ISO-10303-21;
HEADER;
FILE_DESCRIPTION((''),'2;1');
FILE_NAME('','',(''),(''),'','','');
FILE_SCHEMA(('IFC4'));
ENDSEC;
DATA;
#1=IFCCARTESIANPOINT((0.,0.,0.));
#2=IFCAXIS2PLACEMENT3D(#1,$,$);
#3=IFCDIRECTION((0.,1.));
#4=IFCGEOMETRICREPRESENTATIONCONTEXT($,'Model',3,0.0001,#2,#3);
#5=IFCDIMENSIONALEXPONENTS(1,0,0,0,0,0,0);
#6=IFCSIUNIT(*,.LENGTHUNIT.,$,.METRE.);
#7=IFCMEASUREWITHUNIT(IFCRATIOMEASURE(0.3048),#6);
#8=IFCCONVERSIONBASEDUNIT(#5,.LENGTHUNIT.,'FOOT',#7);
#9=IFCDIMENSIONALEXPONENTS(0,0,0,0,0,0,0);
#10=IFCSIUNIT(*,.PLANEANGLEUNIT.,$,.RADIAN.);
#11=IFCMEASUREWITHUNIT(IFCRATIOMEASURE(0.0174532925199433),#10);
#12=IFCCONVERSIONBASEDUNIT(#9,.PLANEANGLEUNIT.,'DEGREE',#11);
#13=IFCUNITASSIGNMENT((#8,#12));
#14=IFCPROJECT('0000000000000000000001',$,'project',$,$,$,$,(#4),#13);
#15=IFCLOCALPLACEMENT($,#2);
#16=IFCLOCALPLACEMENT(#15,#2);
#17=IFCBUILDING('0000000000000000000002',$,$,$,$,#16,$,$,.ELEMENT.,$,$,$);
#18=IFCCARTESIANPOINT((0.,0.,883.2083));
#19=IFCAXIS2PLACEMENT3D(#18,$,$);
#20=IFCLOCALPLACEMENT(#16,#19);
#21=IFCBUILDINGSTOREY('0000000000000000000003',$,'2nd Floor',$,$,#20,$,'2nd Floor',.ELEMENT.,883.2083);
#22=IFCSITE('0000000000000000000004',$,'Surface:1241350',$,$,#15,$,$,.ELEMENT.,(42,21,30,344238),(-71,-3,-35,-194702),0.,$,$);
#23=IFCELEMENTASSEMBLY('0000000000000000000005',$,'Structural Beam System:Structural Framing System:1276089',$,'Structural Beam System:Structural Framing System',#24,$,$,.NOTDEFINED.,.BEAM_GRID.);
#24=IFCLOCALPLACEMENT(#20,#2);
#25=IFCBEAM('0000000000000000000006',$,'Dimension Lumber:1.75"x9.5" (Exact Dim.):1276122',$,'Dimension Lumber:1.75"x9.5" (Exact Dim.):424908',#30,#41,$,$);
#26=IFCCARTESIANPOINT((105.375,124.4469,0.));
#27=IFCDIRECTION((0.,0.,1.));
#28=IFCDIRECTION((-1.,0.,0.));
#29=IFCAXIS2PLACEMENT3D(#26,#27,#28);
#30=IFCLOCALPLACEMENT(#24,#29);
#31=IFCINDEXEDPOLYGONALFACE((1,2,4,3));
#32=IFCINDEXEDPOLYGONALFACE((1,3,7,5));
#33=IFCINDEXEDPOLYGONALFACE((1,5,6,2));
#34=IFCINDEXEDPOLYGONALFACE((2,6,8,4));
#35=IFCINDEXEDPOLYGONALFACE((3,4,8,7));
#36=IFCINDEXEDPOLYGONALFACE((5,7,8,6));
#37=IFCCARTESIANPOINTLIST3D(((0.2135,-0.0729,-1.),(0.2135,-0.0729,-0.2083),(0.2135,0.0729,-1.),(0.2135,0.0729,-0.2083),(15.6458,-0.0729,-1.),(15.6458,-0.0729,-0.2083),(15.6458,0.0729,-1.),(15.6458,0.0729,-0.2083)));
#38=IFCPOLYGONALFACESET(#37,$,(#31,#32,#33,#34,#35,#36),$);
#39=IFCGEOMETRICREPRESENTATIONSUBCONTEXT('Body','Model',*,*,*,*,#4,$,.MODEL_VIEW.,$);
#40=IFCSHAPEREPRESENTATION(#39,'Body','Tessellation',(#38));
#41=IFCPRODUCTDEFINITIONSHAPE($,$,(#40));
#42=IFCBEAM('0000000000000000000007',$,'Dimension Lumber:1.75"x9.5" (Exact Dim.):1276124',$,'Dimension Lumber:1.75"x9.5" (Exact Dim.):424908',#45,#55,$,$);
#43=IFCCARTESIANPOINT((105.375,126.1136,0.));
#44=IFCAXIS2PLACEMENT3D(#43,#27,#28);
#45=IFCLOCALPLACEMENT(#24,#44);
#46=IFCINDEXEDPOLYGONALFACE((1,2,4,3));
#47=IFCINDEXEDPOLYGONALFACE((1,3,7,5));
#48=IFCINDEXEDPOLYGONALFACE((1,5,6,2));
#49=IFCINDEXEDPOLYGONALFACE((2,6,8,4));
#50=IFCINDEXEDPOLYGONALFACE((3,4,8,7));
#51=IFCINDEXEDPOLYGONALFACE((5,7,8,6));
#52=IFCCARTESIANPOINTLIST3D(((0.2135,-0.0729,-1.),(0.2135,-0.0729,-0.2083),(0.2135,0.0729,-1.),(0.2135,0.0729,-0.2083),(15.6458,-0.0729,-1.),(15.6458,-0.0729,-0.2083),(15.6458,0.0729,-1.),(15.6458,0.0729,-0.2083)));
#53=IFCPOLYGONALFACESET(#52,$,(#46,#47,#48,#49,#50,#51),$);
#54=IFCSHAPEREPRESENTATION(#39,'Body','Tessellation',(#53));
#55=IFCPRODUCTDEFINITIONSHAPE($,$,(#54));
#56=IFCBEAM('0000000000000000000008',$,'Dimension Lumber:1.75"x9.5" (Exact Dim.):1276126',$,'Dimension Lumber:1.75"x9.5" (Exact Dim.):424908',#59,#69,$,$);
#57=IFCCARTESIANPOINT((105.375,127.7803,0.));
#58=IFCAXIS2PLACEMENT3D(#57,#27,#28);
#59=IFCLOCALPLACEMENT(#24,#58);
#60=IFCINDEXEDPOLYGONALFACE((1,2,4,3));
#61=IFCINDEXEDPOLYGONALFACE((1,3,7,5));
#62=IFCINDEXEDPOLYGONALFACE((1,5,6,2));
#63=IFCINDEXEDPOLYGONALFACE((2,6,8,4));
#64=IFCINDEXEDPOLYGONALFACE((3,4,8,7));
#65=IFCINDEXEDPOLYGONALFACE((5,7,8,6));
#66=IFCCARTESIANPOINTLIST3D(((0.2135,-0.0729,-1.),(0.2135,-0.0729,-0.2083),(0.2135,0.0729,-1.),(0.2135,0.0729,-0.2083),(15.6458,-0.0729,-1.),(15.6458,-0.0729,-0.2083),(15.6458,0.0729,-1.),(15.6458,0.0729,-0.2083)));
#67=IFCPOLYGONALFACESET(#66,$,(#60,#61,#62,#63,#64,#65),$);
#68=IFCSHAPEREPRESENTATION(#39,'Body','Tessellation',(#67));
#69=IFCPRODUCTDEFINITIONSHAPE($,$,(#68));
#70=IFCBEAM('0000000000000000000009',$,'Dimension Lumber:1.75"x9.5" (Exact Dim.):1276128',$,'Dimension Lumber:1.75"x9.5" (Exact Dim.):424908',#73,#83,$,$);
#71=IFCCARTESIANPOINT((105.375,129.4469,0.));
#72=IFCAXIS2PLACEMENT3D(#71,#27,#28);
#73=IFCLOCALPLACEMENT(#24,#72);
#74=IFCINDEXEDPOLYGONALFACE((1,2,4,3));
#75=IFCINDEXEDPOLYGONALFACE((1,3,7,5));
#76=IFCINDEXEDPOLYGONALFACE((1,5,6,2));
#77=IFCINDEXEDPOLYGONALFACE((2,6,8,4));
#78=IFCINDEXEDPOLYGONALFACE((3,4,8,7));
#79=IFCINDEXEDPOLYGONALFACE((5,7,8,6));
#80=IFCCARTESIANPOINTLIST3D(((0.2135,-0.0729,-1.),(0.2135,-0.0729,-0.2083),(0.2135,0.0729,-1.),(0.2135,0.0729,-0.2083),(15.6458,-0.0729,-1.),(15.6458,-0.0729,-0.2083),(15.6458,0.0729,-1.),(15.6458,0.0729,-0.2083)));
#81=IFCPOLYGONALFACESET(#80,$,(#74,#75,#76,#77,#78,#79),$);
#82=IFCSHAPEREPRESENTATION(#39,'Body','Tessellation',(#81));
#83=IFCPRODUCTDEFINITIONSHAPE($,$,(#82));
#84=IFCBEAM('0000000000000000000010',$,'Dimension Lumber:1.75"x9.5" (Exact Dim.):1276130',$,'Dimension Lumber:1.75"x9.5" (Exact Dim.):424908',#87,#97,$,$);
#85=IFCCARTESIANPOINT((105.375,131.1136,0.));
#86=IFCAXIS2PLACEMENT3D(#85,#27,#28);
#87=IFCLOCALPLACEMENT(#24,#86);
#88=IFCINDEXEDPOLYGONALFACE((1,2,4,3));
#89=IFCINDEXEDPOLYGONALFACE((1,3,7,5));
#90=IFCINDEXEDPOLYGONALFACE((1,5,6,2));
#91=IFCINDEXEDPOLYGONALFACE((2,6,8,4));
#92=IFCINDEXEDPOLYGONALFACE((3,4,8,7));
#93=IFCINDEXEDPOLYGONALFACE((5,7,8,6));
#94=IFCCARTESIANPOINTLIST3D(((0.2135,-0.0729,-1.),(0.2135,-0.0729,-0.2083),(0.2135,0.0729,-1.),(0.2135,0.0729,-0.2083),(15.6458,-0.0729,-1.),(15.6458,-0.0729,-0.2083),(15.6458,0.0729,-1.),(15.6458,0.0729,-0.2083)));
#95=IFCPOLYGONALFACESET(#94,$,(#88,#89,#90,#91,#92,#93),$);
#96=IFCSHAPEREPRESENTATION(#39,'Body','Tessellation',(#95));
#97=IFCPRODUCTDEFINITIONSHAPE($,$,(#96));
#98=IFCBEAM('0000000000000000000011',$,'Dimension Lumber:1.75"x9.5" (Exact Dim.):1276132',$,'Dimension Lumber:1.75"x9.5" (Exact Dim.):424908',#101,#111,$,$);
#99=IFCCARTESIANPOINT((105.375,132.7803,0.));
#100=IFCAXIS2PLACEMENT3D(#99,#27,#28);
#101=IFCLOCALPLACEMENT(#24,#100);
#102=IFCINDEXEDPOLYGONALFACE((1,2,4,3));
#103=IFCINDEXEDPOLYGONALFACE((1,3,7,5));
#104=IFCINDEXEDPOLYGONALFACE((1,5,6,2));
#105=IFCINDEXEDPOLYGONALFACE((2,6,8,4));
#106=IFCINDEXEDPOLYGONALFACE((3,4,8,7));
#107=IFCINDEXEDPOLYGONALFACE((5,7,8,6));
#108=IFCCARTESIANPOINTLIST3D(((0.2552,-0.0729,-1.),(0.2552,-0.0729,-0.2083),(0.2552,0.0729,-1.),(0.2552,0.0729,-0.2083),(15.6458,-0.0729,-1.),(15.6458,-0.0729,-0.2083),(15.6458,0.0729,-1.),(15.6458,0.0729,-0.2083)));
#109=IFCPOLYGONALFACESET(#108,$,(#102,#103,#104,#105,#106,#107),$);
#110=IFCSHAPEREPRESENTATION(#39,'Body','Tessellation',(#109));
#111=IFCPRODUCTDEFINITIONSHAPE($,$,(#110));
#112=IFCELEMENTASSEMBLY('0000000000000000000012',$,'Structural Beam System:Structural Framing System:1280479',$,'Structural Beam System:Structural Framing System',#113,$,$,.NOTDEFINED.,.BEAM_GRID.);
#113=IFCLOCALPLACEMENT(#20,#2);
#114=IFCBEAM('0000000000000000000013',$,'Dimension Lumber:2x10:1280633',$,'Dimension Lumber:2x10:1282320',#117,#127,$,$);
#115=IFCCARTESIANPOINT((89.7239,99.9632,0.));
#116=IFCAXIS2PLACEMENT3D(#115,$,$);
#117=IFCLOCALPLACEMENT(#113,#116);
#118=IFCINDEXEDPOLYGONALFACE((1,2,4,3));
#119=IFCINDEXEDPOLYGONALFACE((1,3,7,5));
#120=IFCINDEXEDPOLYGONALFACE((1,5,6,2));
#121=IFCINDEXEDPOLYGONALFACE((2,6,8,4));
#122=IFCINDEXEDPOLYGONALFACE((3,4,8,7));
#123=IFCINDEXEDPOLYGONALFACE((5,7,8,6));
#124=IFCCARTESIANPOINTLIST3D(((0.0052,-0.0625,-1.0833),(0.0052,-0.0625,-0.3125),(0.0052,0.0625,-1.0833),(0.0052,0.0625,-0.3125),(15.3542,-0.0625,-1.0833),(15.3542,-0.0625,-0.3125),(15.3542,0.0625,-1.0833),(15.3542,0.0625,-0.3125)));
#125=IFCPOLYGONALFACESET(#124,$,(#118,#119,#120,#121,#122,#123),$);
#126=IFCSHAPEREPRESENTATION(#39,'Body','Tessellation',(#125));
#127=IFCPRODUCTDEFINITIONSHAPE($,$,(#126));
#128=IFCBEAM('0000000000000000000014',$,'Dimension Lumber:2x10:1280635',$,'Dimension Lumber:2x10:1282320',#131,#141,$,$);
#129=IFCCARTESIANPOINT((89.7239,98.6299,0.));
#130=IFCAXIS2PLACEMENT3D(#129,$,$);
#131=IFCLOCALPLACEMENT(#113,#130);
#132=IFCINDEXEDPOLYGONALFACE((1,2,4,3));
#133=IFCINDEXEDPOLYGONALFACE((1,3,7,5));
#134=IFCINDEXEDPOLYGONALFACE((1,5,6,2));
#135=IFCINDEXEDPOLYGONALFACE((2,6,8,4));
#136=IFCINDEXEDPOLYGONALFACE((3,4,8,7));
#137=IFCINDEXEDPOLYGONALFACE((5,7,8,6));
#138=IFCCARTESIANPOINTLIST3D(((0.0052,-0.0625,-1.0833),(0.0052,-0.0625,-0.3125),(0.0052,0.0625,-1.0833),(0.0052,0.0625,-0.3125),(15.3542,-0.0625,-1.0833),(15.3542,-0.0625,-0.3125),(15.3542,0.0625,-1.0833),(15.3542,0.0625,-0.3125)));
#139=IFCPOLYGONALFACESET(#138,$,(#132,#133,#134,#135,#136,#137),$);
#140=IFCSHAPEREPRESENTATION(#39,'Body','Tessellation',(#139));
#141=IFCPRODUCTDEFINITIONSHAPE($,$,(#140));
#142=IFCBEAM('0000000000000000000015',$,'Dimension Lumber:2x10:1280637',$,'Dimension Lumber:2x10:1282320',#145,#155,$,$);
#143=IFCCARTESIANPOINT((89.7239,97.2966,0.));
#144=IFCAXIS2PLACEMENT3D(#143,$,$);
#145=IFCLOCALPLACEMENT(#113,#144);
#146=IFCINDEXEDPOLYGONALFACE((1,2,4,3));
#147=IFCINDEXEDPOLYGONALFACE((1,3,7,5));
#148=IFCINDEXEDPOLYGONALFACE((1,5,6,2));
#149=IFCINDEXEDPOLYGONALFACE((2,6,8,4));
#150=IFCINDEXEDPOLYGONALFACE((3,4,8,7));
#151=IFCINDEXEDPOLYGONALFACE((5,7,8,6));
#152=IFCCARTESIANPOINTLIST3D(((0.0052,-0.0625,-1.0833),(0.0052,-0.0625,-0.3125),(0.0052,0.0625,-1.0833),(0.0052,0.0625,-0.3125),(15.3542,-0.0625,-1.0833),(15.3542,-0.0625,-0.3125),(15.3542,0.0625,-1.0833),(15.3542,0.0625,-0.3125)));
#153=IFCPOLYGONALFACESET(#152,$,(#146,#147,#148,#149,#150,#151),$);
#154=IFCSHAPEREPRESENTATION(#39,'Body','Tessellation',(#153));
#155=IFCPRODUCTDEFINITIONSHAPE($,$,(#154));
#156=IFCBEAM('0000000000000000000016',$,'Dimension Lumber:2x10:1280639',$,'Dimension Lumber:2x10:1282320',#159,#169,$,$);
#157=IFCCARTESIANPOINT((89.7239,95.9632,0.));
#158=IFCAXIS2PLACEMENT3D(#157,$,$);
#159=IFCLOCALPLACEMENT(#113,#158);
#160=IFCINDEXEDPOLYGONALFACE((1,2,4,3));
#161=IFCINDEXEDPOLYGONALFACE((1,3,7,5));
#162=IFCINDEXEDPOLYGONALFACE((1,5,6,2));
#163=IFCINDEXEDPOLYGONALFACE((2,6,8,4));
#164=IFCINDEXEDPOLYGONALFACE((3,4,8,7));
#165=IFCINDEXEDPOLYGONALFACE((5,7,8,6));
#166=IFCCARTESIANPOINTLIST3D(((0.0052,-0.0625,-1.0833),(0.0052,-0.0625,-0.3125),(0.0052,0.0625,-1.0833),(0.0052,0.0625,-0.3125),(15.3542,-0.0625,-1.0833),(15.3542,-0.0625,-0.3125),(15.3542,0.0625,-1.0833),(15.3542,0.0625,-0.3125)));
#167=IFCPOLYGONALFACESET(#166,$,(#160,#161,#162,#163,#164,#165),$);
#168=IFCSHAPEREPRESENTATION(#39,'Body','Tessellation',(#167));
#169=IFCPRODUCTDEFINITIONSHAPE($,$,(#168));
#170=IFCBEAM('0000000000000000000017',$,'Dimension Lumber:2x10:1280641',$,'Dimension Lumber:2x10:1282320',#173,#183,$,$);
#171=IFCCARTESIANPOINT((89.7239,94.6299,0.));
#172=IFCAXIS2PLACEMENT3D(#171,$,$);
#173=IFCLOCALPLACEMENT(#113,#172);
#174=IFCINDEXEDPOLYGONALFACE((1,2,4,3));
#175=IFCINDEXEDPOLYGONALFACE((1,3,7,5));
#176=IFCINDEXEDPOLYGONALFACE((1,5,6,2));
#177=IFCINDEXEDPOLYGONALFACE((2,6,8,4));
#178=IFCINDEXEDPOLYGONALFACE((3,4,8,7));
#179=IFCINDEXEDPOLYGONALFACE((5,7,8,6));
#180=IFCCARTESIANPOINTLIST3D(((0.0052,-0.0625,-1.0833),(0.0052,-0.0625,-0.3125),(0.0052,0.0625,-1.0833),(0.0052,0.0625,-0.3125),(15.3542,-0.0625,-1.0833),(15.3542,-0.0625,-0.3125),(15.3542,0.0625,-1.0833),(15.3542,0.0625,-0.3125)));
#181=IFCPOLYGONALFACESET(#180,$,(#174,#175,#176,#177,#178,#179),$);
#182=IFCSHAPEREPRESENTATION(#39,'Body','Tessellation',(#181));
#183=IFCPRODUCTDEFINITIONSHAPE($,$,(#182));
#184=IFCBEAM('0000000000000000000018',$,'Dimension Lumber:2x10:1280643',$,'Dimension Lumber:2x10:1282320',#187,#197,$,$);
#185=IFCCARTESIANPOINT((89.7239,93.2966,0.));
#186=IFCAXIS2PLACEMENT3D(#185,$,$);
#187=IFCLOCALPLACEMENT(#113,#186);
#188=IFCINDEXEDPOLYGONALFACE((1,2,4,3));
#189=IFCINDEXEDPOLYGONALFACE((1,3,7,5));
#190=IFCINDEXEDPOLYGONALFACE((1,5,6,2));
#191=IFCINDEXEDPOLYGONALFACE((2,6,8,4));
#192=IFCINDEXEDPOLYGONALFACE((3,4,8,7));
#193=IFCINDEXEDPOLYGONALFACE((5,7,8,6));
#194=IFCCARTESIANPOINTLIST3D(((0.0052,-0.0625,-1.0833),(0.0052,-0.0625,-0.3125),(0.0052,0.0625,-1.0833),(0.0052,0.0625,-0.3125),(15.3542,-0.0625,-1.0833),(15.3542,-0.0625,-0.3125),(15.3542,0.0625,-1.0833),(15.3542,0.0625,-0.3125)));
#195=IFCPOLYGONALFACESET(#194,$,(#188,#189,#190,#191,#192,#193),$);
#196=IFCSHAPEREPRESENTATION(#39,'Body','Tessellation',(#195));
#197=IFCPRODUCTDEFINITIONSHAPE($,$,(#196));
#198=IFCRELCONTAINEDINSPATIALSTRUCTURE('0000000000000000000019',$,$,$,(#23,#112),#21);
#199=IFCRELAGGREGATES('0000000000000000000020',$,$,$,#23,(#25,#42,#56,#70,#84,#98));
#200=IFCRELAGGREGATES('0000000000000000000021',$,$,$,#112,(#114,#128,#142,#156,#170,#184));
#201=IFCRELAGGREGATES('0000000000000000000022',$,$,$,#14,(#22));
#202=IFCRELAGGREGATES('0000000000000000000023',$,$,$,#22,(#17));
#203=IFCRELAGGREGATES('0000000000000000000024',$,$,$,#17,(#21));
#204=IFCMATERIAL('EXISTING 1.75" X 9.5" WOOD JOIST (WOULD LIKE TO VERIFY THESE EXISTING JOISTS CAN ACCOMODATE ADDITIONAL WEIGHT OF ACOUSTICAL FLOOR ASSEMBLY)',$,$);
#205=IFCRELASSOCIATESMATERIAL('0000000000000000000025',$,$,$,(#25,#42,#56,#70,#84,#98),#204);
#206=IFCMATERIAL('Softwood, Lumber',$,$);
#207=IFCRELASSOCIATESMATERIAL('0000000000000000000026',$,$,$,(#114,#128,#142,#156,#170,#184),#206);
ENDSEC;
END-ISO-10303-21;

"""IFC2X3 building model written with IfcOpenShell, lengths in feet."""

from ifc_helpers import new_model, entity, si_unit, converted_unit, direction, frame, frame_2d, origin, origin_2d_with_axis, place, context, subcontext, project, spatial, rectangle, extrude, material, element, aggregate, save


model = new_model("IFC2X3")

# Units and contexts
model_context = context("Model", 3, precision=0.0001, world=origin(), true_north=direction((0.0, 1.0)))
body_context = subcontext(model_context, "Body", "Model", "MODEL_VIEW")
ifc_project = project(units=[converted_unit("LENGTHUNIT", "FOOT", entity("IfcRatioMeasure", 0.3048), si_unit("LENGTHUNIT", "METRE"), dimensions=[1, 0, 0, 0, 0, 0, 0]), converted_unit("PLANEANGLEUNIT", "DEGREE", entity("IfcRatioMeasure", 0.0174532925199433), si_unit("PLANEANGLEUNIT", "RADIAN"), dimensions=[0, 0, 0, 0, 0, 0, 0])], contexts=[model_context])

# Site, building, storey
site_placement = place(None, origin())
site = spatial("IfcSite", under=ifc_project, at=site_placement, Name="Surface:1241350", CompositionType="ELEMENT", RefLatitude=(42, 21, 30, 344238), RefLongitude=(-71, -3, -35, -194702), RefElevation=0.0)
building_placement = place(site_placement, origin())
building = spatial("IfcBuilding", under=site, at=building_placement, CompositionType="ELEMENT")
storey_placement = place(building_placement, frame((0.0, 0.0, 883.2083)))
storey = spatial("IfcBuildingStorey", under=building, at=storey_placement, Name="2nd Floor", LongName="2nd Floor", CompositionType="ELEMENT", Elevation=883.2083)

# Element assemblies, beams
assembly_1_placement = place(storey_placement, origin())
assembly_1 = element("IfcElementAssembly", 1, at=assembly_1_placement, inside=storey, Name="Structural Beam System:Structural Framing System:1276089", ObjectType="Structural Beam System:Structural Framing System", AssemblyPlace="NOTDEFINED", PredefinedType="BEAM_GRID")
ifc_material_1 = material(Name="EXISTING 1.75\" X 9.5\" WOOD JOIST (WOULD LIKE TO VERIFY THESE EXISTING JOISTS CAN ACCOMODATE ADDITIONAL WEIGHT OF ACOUSTICAL FLOOR ASSEMBLY)")
beam_1_placement = place(assembly_1_placement, frame((105.375, 124.4469, 0.0), z_axis=(0.0, 0.0, 1.0), x_axis=(-1.0, 0.0, 0.0)))
beam_1 = element("IfcBeam", 2, at=beam_1_placement, material=ifc_material_1, Name="Dimension Lumber:1.75\"x9.5\" (Exact Dim.):1276122", ObjectType="Dimension Lumber:1.75\"x9.5\" (Exact Dim.):424908", context=body_context, shape_type="SweptSolid", body=[
    extrude(rectangle(XDim=0.7917, YDim=0.1458, at=origin_2d_with_axis()), frame((0.2135, 0.0, -0.6042), z_axis=(1.0, 0.0, 0.0), x_axis=(0.0, 0.0, -1.0)), (0.0, 0.0, 1.0), 15.4323),
])
beam_2_placement = place(assembly_1_placement, frame((105.375, 126.1136, 0.0), z_axis=(0.0, 0.0, 1.0), x_axis=(-1.0, 0.0, 0.0)))
beam_2 = element("IfcBeam", 3, at=beam_2_placement, material=ifc_material_1, Name="Dimension Lumber:1.75\"x9.5\" (Exact Dim.):1276124", ObjectType="Dimension Lumber:1.75\"x9.5\" (Exact Dim.):424908", context=body_context, shape_type="SweptSolid", body=[
    extrude(rectangle(XDim=0.7917, YDim=0.1458, at=origin_2d_with_axis()), frame((0.2135, 0.0, -0.6042), z_axis=(1.0, 0.0, 0.0), x_axis=(0.0, 0.0, -1.0)), (0.0, 0.0, 1.0), 15.4323),
])
beam_3_placement = place(assembly_1_placement, frame((105.375, 127.7803, 0.0), z_axis=(0.0, 0.0, 1.0), x_axis=(-1.0, 0.0, 0.0)))
beam_3 = element("IfcBeam", 4, at=beam_3_placement, material=ifc_material_1, Name="Dimension Lumber:1.75\"x9.5\" (Exact Dim.):1276126", ObjectType="Dimension Lumber:1.75\"x9.5\" (Exact Dim.):424908", context=body_context, shape_type="SweptSolid", body=[
    extrude(rectangle(XDim=0.7917, YDim=0.1458, at=frame_2d((0.0, 0.0), x_axis=(1.0, 0.0))), frame((0.2135, 0.0, -0.6042), z_axis=(1.0, 0.0, 0.0), x_axis=(0.0, 0.0, -1.0)), (0.0, 0.0, 1.0), 15.4323),
])
beam_4_placement = place(assembly_1_placement, frame((105.375, 129.4469, 0.0), z_axis=(0.0, 0.0, 1.0), x_axis=(-1.0, 0.0, 0.0)))
beam_4 = element("IfcBeam", 5, at=beam_4_placement, material=ifc_material_1, Name="Dimension Lumber:1.75\"x9.5\" (Exact Dim.):1276128", ObjectType="Dimension Lumber:1.75\"x9.5\" (Exact Dim.):424908", context=body_context, shape_type="SweptSolid", body=[
    extrude(rectangle(XDim=0.7917, YDim=0.1458, at=frame_2d((0.0, 0.0), x_axis=(1.0, 0.0))), frame((0.2135, 0.0, -0.6042), z_axis=(1.0, 0.0, 0.0), x_axis=(0.0, 0.0, -1.0)), (0.0, 0.0, 1.0), 15.4323),
])
beam_5_placement = place(assembly_1_placement, frame((105.375, 131.1136, 0.0), z_axis=(0.0, 0.0, 1.0), x_axis=(-1.0, 0.0, 0.0)))
beam_5 = element("IfcBeam", 6, at=beam_5_placement, material=ifc_material_1, Name="Dimension Lumber:1.75\"x9.5\" (Exact Dim.):1276130", ObjectType="Dimension Lumber:1.75\"x9.5\" (Exact Dim.):424908", context=body_context, shape_type="SweptSolid", body=[
    extrude(rectangle(XDim=0.7917, YDim=0.1458, at=frame_2d((0.0, 0.0), x_axis=(1.0, 0.0))), frame((0.2135, 0.0, -0.6042), z_axis=(1.0, 0.0, 0.0), x_axis=(0.0, 0.0, -1.0)), (0.0, 0.0, 1.0), 15.4323),
])
beam_6_placement = place(assembly_1_placement, frame((105.375, 132.7803, 0.0), z_axis=(0.0, 0.0, 1.0), x_axis=(-1.0, 0.0, 0.0)))
beam_6 = element("IfcBeam", 7, at=beam_6_placement, material=ifc_material_1, Name="Dimension Lumber:1.75\"x9.5\" (Exact Dim.):1276132", ObjectType="Dimension Lumber:1.75\"x9.5\" (Exact Dim.):424908", context=body_context, shape_type="SweptSolid", body=[
    extrude(rectangle(XDim=0.7917, YDim=0.1458, at=frame_2d((0.0, 0.0), x_axis=(1.0, 0.0))), frame((0.2552, 0.0, -0.6042), z_axis=(1.0, 0.0, 0.0), x_axis=(0.0, 0.0, -1.0)), (0.0, 0.0, 1.0), 15.3906),
])
aggregate(assembly_1, [beam_1, beam_2, beam_3, beam_4, beam_5, beam_6])
assembly_2_placement = place(storey_placement, origin())
assembly_2 = element("IfcElementAssembly", 8, at=assembly_2_placement, inside=storey, Name="Structural Beam System:Structural Framing System:1280479", ObjectType="Structural Beam System:Structural Framing System", AssemblyPlace="NOTDEFINED", PredefinedType="BEAM_GRID")
ifc_material_2 = material(Name="Softwood, Lumber")
beam_7_placement = place(assembly_2_placement, frame((89.7239, 99.9632, 0.0)))
beam_7 = element("IfcBeam", 9, at=beam_7_placement, material=ifc_material_2, Name="Dimension Lumber:2x10:1280633", ObjectType="Dimension Lumber:2x10:1282320", context=body_context, shape_type="SweptSolid", body=[
    extrude(rectangle(XDim=0.7708, YDim=0.125, at=frame_2d((0.0, 0.0), x_axis=(1.0, 0.0))), frame((0.0052, 0.0, -0.6979), z_axis=(1.0, 0.0, 0.0), x_axis=(0.0, 0.0, -1.0)), (0.0, 0.0, 1.0), 15.349),
])
beam_8_placement = place(assembly_2_placement, frame((89.7239, 98.6299, 0.0)))
beam_8 = element("IfcBeam", 10, at=beam_8_placement, material=ifc_material_2, Name="Dimension Lumber:2x10:1280635", ObjectType="Dimension Lumber:2x10:1282320", context=body_context, shape_type="SweptSolid", body=[
    extrude(rectangle(XDim=0.7708, YDim=0.125, at=frame_2d((0.0, 0.0), x_axis=(1.0, 0.0))), frame((0.0052, 0.0, -0.6979), z_axis=(1.0, 0.0, 0.0), x_axis=(0.0, 0.0, -1.0)), (0.0, 0.0, 1.0), 15.349),
])
beam_9_placement = place(assembly_2_placement, frame((89.7239, 97.2966, 0.0)))
beam_9 = element("IfcBeam", 11, at=beam_9_placement, material=ifc_material_2, Name="Dimension Lumber:2x10:1280637", ObjectType="Dimension Lumber:2x10:1282320", context=body_context, shape_type="SweptSolid", body=[
    extrude(rectangle(XDim=0.7708, YDim=0.125, at=frame_2d((0.0, 0.0), x_axis=(1.0, 0.0))), frame((0.0052, 0.0, -0.6979), z_axis=(1.0, 0.0, 0.0), x_axis=(0.0, 0.0, -1.0)), (0.0, 0.0, 1.0), 15.349),
])
beam_10_placement = place(assembly_2_placement, frame((89.7239, 95.9632, 0.0)))
beam_10 = element("IfcBeam", 12, at=beam_10_placement, material=ifc_material_2, Name="Dimension Lumber:2x10:1280639", ObjectType="Dimension Lumber:2x10:1282320", context=body_context, shape_type="SweptSolid", body=[
    extrude(rectangle(XDim=0.7708, YDim=0.125, at=frame_2d((0.0, 0.0), x_axis=(1.0, 0.0))), frame((0.0052, 0.0, -0.6979), z_axis=(1.0, 0.0, 0.0), x_axis=(0.0, 0.0, -1.0)), (0.0, 0.0, 1.0), 15.349),
])
beam_11_placement = place(assembly_2_placement, frame((89.7239, 94.6299, 0.0)))
beam_11 = element("IfcBeam", 13, at=beam_11_placement, material=ifc_material_2, Name="Dimension Lumber:2x10:1280641", ObjectType="Dimension Lumber:2x10:1282320", context=body_context, shape_type="SweptSolid", body=[
    extrude(rectangle(XDim=0.7708, YDim=0.125, at=frame_2d((0.0, 0.0), x_axis=(1.0, 0.0))), frame((0.0052, 0.0, -0.6979), z_axis=(1.0, 0.0, 0.0), x_axis=(0.0, 0.0, -1.0)), (0.0, 0.0, 1.0), 15.349),
])
beam_12_placement = place(assembly_2_placement, frame((89.7239, 93.2966, 0.0)))
beam_12 = element("IfcBeam", 14, at=beam_12_placement, material=ifc_material_2, Name="Dimension Lumber:2x10:1280643", ObjectType="Dimension Lumber:2x10:1282320", context=body_context, shape_type="SweptSolid", body=[
    extrude(rectangle(XDim=0.7708, YDim=0.125, at=frame_2d((0.0, 0.0), x_axis=(1.0, 0.0))), frame((0.0052, 0.0, -0.6979), z_axis=(1.0, 0.0, 0.0), x_axis=(0.0, 0.0, -1.0)), (0.0, 0.0, 1.0), 15.349),
])
aggregate(assembly_2, [beam_7, beam_8, beam_9, beam_10, beam_11, beam_12])

save(model, "model.ifc")
